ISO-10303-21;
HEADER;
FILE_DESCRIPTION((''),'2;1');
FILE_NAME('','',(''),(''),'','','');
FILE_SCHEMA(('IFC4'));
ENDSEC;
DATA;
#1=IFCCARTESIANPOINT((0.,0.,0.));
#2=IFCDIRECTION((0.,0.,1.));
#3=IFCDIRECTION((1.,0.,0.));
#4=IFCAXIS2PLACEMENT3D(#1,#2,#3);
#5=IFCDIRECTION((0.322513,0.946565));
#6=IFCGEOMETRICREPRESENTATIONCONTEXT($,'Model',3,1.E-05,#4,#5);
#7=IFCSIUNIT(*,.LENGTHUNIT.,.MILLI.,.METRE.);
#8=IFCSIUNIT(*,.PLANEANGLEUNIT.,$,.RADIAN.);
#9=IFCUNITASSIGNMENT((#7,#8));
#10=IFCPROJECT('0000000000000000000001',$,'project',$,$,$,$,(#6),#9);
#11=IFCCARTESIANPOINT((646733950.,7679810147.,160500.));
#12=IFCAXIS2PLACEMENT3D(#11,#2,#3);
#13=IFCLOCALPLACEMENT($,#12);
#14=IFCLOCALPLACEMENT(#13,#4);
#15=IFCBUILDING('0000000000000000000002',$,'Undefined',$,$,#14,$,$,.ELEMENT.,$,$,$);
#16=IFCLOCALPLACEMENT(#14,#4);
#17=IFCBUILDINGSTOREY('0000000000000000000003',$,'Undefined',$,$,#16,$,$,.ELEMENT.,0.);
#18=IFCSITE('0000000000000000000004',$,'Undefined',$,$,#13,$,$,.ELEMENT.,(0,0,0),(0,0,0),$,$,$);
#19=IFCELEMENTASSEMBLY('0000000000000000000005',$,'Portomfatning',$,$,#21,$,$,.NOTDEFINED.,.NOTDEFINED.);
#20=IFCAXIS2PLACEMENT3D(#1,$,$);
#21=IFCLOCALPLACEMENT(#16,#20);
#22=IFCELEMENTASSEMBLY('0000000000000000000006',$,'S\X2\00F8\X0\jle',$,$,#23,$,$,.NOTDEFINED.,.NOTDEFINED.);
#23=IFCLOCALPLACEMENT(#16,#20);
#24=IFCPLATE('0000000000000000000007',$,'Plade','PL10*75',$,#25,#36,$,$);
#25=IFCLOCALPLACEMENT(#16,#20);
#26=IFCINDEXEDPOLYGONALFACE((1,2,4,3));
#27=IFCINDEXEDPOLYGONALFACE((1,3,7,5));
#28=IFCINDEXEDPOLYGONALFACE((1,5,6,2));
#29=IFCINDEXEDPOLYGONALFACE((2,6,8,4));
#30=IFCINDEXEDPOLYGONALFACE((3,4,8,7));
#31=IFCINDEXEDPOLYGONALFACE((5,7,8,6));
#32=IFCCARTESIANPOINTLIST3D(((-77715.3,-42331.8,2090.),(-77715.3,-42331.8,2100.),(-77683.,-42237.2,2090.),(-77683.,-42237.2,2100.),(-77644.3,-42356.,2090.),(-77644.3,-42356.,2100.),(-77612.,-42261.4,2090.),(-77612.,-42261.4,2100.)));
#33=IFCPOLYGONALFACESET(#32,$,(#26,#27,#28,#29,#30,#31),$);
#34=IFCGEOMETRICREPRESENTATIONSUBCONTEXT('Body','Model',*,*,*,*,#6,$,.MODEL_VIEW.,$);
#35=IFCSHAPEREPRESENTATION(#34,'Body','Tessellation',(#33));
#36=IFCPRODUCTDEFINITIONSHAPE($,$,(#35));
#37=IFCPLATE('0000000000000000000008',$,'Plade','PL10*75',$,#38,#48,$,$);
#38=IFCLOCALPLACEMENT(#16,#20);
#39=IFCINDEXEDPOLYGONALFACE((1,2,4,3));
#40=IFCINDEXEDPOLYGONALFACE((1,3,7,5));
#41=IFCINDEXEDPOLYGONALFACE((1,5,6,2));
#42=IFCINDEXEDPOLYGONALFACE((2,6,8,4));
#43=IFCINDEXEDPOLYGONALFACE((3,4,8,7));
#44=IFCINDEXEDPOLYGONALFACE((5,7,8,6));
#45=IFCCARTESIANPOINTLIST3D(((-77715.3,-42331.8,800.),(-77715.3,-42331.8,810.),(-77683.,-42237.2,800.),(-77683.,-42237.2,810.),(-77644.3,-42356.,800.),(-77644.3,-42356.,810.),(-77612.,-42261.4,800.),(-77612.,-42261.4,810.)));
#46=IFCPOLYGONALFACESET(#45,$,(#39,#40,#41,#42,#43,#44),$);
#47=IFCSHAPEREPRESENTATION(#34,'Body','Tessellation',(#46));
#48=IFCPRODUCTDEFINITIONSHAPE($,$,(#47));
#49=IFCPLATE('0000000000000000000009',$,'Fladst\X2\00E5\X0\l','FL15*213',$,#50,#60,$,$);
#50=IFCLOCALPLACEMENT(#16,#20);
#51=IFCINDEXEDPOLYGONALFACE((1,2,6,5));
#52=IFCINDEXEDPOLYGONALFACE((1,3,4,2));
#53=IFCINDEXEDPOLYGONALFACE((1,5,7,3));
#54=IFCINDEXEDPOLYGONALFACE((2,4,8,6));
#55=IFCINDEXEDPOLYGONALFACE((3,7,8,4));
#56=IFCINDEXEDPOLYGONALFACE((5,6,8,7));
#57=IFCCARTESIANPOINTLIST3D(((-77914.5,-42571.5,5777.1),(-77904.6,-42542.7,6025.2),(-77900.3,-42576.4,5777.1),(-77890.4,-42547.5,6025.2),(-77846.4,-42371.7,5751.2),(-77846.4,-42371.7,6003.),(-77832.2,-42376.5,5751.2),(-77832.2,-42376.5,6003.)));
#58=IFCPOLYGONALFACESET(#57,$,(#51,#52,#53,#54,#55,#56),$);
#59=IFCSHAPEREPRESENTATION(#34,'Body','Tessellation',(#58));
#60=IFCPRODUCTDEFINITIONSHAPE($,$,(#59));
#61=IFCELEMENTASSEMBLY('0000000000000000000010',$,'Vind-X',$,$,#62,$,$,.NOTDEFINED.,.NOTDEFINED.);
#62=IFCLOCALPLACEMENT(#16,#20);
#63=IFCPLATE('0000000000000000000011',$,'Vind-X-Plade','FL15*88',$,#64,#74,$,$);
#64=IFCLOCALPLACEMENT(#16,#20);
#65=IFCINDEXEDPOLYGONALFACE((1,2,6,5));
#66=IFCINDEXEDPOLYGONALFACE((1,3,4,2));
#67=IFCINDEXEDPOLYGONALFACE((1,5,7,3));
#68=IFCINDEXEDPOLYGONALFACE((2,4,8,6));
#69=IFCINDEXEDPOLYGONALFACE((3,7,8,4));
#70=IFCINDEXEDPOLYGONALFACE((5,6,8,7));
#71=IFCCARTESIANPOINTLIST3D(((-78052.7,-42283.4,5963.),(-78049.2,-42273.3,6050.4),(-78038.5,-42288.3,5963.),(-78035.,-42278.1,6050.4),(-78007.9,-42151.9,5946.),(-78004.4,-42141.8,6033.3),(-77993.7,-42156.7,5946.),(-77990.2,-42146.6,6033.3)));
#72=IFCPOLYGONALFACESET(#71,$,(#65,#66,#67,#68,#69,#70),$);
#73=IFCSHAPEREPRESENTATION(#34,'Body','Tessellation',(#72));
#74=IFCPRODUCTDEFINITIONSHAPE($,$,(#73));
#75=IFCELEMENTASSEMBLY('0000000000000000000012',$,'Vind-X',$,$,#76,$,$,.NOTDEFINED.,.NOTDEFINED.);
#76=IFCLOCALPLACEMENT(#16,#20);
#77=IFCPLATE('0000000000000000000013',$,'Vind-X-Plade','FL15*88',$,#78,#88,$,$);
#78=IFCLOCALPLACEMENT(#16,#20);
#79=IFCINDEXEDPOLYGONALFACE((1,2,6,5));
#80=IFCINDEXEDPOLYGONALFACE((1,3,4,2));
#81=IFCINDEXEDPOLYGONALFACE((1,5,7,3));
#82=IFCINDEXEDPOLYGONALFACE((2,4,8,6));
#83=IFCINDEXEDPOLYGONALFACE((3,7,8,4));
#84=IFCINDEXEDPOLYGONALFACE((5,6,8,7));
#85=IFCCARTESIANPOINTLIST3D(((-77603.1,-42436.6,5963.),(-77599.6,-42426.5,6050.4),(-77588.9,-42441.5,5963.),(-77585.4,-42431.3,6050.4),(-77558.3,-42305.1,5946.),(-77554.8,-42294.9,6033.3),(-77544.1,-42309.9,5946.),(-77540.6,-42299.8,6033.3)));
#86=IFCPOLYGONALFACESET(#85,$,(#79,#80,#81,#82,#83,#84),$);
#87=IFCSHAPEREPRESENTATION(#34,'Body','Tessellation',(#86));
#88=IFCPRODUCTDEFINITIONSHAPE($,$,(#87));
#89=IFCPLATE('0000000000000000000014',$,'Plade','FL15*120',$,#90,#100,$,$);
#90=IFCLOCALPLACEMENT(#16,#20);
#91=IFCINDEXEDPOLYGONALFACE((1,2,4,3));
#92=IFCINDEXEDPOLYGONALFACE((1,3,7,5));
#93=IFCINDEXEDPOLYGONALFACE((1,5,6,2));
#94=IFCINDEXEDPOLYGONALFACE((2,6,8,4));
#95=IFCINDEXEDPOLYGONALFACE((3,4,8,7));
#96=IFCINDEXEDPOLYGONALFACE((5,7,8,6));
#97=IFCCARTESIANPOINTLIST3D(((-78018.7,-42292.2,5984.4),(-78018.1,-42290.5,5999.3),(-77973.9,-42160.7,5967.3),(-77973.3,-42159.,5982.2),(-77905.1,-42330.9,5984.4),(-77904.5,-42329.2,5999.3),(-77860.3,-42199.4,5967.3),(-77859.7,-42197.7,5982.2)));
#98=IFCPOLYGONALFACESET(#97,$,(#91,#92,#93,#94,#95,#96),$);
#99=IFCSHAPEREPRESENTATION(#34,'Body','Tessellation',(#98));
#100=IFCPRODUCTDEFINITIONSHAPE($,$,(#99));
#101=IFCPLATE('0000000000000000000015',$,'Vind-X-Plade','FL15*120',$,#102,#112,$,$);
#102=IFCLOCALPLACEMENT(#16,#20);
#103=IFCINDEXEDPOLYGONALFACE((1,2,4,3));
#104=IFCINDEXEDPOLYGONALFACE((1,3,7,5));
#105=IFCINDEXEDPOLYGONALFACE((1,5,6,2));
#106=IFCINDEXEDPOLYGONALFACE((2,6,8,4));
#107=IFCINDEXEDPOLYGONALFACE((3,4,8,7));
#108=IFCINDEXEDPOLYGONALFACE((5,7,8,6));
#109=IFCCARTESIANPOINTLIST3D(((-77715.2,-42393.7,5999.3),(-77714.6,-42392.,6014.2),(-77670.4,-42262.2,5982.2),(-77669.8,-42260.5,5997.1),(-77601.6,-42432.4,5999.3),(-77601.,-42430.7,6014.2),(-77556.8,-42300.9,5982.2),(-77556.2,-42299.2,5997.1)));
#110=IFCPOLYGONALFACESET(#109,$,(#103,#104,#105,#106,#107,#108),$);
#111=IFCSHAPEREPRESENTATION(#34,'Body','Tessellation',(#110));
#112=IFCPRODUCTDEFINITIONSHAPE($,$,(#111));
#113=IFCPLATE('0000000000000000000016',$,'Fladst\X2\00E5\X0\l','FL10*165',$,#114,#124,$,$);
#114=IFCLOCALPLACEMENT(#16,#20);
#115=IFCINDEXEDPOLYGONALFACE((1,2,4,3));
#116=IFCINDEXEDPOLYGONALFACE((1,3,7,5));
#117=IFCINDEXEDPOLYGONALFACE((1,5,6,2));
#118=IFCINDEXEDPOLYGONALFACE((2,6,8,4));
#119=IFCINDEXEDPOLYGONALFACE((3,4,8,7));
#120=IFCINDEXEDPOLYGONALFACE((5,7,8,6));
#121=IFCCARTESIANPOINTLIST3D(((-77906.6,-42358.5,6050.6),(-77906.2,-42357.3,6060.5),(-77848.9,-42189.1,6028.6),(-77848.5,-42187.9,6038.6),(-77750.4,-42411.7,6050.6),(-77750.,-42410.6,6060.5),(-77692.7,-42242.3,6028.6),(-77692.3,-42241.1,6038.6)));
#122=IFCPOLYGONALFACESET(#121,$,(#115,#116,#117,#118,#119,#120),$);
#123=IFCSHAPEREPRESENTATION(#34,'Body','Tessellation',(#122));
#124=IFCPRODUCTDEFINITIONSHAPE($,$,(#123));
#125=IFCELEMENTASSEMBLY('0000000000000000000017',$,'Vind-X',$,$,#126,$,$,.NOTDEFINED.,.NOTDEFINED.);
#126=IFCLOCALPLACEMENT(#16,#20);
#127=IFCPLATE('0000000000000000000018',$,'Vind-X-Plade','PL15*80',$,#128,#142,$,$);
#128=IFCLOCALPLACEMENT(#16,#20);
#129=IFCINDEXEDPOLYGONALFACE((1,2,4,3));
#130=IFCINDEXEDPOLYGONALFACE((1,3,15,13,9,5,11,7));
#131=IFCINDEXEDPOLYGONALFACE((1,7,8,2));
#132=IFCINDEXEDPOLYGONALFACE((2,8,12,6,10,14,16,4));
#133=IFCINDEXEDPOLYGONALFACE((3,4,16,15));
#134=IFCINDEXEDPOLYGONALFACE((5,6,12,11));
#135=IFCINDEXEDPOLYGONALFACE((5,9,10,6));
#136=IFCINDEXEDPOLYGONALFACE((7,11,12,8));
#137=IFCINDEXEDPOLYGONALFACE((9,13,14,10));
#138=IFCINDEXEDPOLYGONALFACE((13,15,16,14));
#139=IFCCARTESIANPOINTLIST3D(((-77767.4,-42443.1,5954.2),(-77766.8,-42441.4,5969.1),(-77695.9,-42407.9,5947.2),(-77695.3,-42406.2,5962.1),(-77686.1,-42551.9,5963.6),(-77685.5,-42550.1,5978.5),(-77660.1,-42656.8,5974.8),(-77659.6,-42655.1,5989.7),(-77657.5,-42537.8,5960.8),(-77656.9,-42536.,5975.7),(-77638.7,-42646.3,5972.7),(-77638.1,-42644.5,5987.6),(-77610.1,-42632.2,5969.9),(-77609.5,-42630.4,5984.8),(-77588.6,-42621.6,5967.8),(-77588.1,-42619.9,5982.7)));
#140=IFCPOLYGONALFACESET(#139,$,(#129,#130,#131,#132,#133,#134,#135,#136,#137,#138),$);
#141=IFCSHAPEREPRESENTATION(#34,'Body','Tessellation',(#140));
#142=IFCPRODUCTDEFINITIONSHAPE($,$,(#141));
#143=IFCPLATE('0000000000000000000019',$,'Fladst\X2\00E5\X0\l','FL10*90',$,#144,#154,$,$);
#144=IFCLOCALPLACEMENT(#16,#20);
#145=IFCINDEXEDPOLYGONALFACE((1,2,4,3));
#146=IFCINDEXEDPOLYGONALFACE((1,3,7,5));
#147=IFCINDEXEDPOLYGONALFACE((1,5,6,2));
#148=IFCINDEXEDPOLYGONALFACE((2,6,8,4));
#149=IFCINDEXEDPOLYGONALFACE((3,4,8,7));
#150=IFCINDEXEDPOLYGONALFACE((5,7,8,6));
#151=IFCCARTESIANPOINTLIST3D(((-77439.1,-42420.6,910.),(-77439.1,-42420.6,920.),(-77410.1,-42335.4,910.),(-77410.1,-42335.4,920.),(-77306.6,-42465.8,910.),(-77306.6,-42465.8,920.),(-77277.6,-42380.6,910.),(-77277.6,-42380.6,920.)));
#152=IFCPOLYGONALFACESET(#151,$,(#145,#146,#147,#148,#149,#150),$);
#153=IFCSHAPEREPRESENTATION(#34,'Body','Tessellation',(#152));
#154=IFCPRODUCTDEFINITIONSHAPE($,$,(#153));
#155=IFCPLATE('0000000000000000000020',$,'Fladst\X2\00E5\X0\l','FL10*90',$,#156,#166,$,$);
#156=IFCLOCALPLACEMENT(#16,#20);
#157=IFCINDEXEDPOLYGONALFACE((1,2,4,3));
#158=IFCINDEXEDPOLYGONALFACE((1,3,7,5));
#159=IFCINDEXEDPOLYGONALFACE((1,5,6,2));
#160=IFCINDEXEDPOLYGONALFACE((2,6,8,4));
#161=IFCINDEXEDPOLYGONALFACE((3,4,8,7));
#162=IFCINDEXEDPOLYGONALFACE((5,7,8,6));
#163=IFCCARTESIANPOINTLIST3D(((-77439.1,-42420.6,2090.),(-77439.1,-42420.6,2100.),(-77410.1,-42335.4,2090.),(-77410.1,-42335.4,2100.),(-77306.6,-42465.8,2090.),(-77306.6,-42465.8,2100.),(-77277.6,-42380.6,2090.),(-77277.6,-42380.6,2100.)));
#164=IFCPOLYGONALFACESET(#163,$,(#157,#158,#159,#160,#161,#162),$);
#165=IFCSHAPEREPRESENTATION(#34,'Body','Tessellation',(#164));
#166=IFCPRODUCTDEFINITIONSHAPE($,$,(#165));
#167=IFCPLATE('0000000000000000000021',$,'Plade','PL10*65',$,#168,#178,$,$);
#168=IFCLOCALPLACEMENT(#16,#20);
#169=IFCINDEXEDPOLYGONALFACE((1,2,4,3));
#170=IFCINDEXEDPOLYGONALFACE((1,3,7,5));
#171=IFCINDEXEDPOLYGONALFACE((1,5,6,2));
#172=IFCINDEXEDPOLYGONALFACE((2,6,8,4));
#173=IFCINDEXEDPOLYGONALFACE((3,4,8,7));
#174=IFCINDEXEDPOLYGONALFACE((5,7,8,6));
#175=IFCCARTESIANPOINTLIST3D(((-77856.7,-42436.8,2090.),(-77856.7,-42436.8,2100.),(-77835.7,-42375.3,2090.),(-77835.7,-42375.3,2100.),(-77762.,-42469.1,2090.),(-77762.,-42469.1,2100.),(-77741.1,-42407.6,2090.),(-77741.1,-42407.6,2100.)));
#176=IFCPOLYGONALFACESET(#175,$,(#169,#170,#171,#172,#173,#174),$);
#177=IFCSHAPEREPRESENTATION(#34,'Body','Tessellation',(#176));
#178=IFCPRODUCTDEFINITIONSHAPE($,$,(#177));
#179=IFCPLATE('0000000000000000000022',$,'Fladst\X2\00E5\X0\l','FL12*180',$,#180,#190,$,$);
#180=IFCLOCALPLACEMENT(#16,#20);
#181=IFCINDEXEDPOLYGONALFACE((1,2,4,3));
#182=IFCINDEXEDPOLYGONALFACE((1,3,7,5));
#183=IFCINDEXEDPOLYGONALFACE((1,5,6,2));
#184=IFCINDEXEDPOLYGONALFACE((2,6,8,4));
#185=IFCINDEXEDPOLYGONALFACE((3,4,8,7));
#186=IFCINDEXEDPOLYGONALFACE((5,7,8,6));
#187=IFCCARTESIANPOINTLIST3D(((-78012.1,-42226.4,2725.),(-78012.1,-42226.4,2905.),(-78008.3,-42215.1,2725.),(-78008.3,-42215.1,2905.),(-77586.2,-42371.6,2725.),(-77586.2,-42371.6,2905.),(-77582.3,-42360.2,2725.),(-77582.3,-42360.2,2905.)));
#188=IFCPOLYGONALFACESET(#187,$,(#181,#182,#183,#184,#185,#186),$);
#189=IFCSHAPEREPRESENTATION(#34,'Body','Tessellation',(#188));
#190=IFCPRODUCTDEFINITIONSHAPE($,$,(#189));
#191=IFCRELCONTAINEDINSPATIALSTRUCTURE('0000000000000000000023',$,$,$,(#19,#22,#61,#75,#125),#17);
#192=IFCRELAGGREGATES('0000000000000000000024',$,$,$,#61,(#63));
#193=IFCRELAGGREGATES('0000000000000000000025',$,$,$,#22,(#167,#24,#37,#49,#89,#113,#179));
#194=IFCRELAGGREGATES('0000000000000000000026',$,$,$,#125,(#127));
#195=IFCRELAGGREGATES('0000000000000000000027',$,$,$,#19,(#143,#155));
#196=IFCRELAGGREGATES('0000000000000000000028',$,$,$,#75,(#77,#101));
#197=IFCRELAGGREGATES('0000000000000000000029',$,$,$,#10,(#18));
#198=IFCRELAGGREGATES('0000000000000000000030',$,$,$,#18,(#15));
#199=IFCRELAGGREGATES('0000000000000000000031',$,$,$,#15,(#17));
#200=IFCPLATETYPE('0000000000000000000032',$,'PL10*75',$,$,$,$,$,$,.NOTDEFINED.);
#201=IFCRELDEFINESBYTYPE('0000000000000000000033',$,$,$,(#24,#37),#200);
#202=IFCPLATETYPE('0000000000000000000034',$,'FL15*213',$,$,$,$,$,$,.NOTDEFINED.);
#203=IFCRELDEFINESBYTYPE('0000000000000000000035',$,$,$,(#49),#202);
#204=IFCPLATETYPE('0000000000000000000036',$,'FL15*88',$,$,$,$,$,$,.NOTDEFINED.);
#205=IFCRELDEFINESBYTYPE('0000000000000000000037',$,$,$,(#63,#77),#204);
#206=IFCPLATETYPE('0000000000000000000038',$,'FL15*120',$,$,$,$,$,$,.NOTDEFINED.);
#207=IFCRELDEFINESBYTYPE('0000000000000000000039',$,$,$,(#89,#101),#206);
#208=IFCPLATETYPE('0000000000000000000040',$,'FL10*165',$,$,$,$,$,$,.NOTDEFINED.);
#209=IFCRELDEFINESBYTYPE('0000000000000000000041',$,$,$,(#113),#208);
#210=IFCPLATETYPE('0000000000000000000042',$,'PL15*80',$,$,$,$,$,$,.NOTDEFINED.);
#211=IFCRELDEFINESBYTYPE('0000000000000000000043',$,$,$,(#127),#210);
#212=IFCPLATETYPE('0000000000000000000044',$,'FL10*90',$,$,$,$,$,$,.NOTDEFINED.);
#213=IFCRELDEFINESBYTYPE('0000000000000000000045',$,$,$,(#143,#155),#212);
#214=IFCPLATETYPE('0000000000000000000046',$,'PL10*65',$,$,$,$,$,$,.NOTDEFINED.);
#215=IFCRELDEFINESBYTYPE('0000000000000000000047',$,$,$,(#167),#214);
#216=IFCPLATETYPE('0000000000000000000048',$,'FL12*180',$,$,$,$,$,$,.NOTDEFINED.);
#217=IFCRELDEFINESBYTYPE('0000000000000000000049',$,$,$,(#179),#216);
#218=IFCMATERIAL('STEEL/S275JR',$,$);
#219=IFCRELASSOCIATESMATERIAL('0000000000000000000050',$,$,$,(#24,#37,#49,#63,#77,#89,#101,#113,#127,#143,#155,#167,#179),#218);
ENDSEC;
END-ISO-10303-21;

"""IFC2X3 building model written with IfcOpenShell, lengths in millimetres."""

from ifc_helpers import new_model, si_unit, direction, frame, origin_with_axes, place, context, subcontext, project, spatial, polyline, outline, extrude, boolean, material, type_object, element, aggregate, save


model = new_model("IFC2X3")

# Units and contexts
model_context = context("Model", 3, precision=1e-05, world=origin_with_axes(), true_north=direction((0.322513, 0.946565)))
body_context = subcontext(model_context, "Body", "Model", "MODEL_VIEW")
ifc_project = project(units=[si_unit("LENGTHUNIT", "METRE", prefix="MILLI"), si_unit("PLANEANGLEUNIT", "RADIAN")], contexts=[model_context])

# Site, building, storey
site_placement = place(None, frame((646733950.0, 7679810147.0, 160500.0), z_axis=(0.0, 0.0, 1.0), x_axis=(1.0, 0.0, 0.0)))
site = spatial("IfcSite", under=ifc_project, at=site_placement, Name="Undefined", CompositionType="ELEMENT", RefLatitude=(0, 0, 0), RefLongitude=(0, 0, 0))
building_placement = place(site_placement, origin_with_axes())
building = spatial("IfcBuilding", under=site, at=building_placement, Name="Undefined", CompositionType="ELEMENT")
storey_placement = place(building_placement, origin_with_axes())
storey = spatial("IfcBuildingStorey", under=building, at=storey_placement, Name="Undefined", CompositionType="ELEMENT", Elevation=0.0)

# Element assemblies
assembly_1_placement = place(storey_placement, origin_with_axes())
assembly_1 = element("IfcElementAssembly", 1, at=assembly_1_placement, inside=storey, Name="Portomfatning", AssemblyPlace="NOTDEFINED", PredefinedType="NOTDEFINED")
assembly_2_placement = place(storey_placement, origin_with_axes())
assembly_2 = element("IfcElementAssembly", 2, at=assembly_2_placement, inside=storey, Name="Søjle", AssemblyPlace="NOTDEFINED", PredefinedType="NOTDEFINED")

# Plates
ifc_material_1 = material(Name="STEEL/S275JR")
plate_type_1 = type_object("IfcPlateType", Name="PL10*75", PredefinedType="NOTDEFINED")
plate_1_placement = place(assembly_2_placement, frame((-77715.3, -42331.8, 2095.0), z_axis=(0.0, 0.0, 1.0), x_axis=(0.946565, -0.322513, 0.0)))
plate_1 = element("IfcPlate", 3, at=plate_1_placement, type_object=plate_type_1, material=ifc_material_1, Name="Plade", Description="PL10*75", context=body_context, shape_type="SweptSolid", body=[
    extrude(outline(polyline([(0.0, 0.0), (75.0, 0.0), (75.0, 100.0), (0.0, 100.0), (0.0, 0.0)])), frame((0.0, 0.0, -5.0), z_axis=(0.0, 0.0, 1.0), x_axis=(1.0, 0.0, 0.0)), (0.0, 0.0, 1.0), 10.0),
])
plate_2_placement = place(assembly_2_placement, frame((-77715.3, -42331.8, 805.0), z_axis=(0.0, 0.0, 1.0), x_axis=(0.946565, -0.322513, 0.0)))
plate_2 = element("IfcPlate", 4, at=plate_2_placement, type_object=plate_type_1, material=ifc_material_1, Name="Plade", Description="PL10*75", context=body_context, shape_type="SweptSolid", body=[
    extrude(outline(polyline([(0.0, 0.0), (75.0, 0.0), (75.0, 100.0), (0.0, 100.0), (0.0, 0.0)])), frame((0.0, 0.0, -5.0), z_axis=(0.0, 0.0, 1.0), x_axis=(1.0, 0.0, 0.0)), (0.0, 0.0, 1.0), 10.0),
])
plate_type_2 = type_object("IfcPlateType", Name="FL15*213", PredefinedType="NOTDEFINED")
plate_3_placement = place(assembly_2_placement, frame((-77839.3, -42374.1, 6003.0), z_axis=(-0.946565, 0.322513, 0.0), x_axis=(0.0, 0.0, -1.0)))
plate_3 = element("IfcPlate", 5, at=plate_3_placement, type_object=plate_type_2, material=ifc_material_1, Name="Fladstål", Description="FL15*213", context=body_context, shape_type="SweptSolid", body=[
    extrude(outline(polyline([(0.0, 0.0), (251.9, 0.0), (226.0, 211.1), (-22.2, 180.7), (0.0, 0.0)])), frame((0.0, 0.0, -7.5), z_axis=(0.0, 0.0, 1.0), x_axis=(1.0, 0.0, 0.0)), (0.0, 0.0, 1.0), 15.0),
])

# Element assemblies, plates
assembly_3_placement = place(storey_placement, origin_with_axes())
assembly_3 = element("IfcElementAssembly", 6, at=assembly_3_placement, inside=storey, Name="Vind-X", AssemblyPlace="NOTDEFINED", PredefinedType="NOTDEFINED")
plate_type_3 = type_object("IfcPlateType", Name="FL15*88", PredefinedType="NOTDEFINED")
plate_4_placement = place(assembly_3_placement, frame((-78045.6, -42285.9, 5963.0), z_axis=(0.946565, -0.322513, 0.0), x_axis=(0.320109, 0.93951, -0.121869)))
plate_4 = element("IfcPlate", 7, at=plate_4_placement, type_object=plate_type_3, material=ifc_material_1, Name="Vind-X-Plade", Description="FL15*88", context=body_context, shape_type="SweptSolid", body=[
    extrude(outline(polyline([(0.0, 0.0), (140.0, 0.0), (140.0, 88.0), (0.0, 88.0), (0.0, 0.0)])), frame((0.0, 0.0, -7.5), z_axis=(0.0, 0.0, 1.0), x_axis=(1.0, 0.0, 0.0)), (0.0, 0.0, 1.0), 15.0),
])
aggregate(assembly_3, [plate_4])
assembly_4_placement = place(storey_placement, origin_with_axes())
assembly_4 = element("IfcElementAssembly", 8, at=assembly_4_placement, inside=storey, Name="Vind-X", AssemblyPlace="NOTDEFINED", PredefinedType="NOTDEFINED")
plate_5_placement = place(assembly_4_placement, frame((-77592.5, -42428.9, 6050.4), z_axis=(-0.946565, 0.322513, 0.0), x_axis=(0.320109, 0.93951, -0.121869)))
plate_5 = element("IfcPlate", 9, at=plate_5_placement, type_object=plate_type_3, material=ifc_material_1, Name="Vind-X-Plade", Description="FL15*88", context=body_context, shape_type="SweptSolid", body=[
    extrude(outline(polyline([(0.0, 0.0), (140.0, 0.0), (140.0, 88.0), (0.0, 88.0), (0.0, 0.0)])), frame((0.0, 0.0, -7.5), z_axis=(0.0, 0.0, 1.0), x_axis=(1.0, 0.0, 0.0)), (0.0, 0.0, 1.0), 15.0),
])

# Plates
plate_type_4 = type_object("IfcPlateType", Name="FL15*120", PredefinedType="NOTDEFINED")
plate_6_placement = place(assembly_2_placement, frame((-77904.8, -42330.1, 5991.8), z_axis=(0.039304, 0.115357, 0.992546), x_axis=(0.320109, 0.93951, -0.121869)))
plate_6 = element("IfcPlate", 10, at=plate_6_placement, type_object=plate_type_4, material=ifc_material_1, Name="Plade", Description="FL15*120", context=body_context, shape_type="SweptSolid", body=[
    extrude(outline(polyline([(0.0, 0.0), (140.0, 0.0), (140.0, 120.0), (0.0, 120.0), (0.0, 0.0)])), frame((0.0, 0.0, -7.5), z_axis=(0.0, 0.0, 1.0), x_axis=(1.0, 0.0, 0.0)), (0.0, 0.0, 1.0), 15.0),
])
plate_7_placement = place(assembly_4_placement, frame((-77692.5, -42327.1, 5998.2), z_axis=(0.039304, 0.115357, 0.992546), x_axis=(0.946565, -0.322513, 0.0)))
plate_7 = element("IfcPlate", 11, at=plate_7_placement, type_object=plate_type_4, material=ifc_material_1, Name="Vind-X-Plade", Description="FL15*120", context=body_context, shape_type="SweptSolid", body=[
    extrude(outline(polyline([(0.0, -70.0), (0.0, 70.0), (120.0, 70.0), (120.0, -70.0), (0.0, -70.0)])), frame((0.0, 0.0, -7.5), z_axis=(0.0, 0.0, 1.0), x_axis=(1.0, 0.0, 0.0)), (0.0, 0.0, 1.0), 15.0),
])
plate_type_5 = type_object("IfcPlateType", Name="FL10*165", PredefinedType="NOTDEFINED")
plate_8_placement = place(assembly_2_placement, frame((-77828.3, -42384.5, 6055.6), z_axis=(-0.039304, -0.115357, -0.992546), x_axis=(0.320109, 0.93951, -0.121869)))
plate_8 = element("IfcPlate", 12, at=plate_8_placement, type_object=plate_type_5, material=ifc_material_1, Name="Fladstål", Description="FL10*165", context=body_context, shape_type="SweptSolid", body=[
    extrude(outline(polyline([(0.0, -82.5), (0.0, 82.5), (180.4, 82.5), (180.4, -82.5), (0.0, -82.5)])), frame((0.0, 0.0, -5.0), z_axis=(0.0, 0.0, 1.0), x_axis=(1.0, 0.0, 0.0)), (0.0, 0.0, 1.0), 10.0),
])

# Element assembly, plate
assembly_5_placement = place(storey_placement, origin_with_axes())
assembly_5 = element("IfcElementAssembly", 13, at=assembly_5_placement, inside=storey, Name="Vind-X", AssemblyPlace="NOTDEFINED", PredefinedType="NOTDEFINED")
plate_type_6 = type_object("IfcPlateType", Name="PL15*80", PredefinedType="NOTDEFINED")
plate_9_placement = place(assembly_5_placement, frame((-77767.1, -42442.2, 5961.6), z_axis=(-0.039304, -0.115357, -0.992546), x_axis=(0.893742, 0.440152, -0.086548)))
plate_9 = element("IfcPlate", 14, at=plate_9_placement, type_object=plate_type_6, material=ifc_material_1, Name="Vind-X-Plade", Description="PL15*80", context=body_context, shape_type="CSG", body=[
    boolean("DIFFERENCE", extrude(outline(polyline([(0.0, 0.0), (80.0, 0.0), (80.0, 240.0), (0.0, 240.0), (0.0, 0.0)])), frame((0.0, 0.0, -7.5), z_axis=(0.0, 0.0, 1.0), x_axis=(1.0, 0.0, 0.0)), (0.0, 0.0, 1.0), 15.0), extrude(outline(polyline([(0.0, 0.0), (106.0, 0.0), (106.0, 32.0), (0.0, 32.0), (0.0, 0.0)])), frame((56.0, 240.0, 8.5), z_axis=(0.0, 0.0, -1.0), x_axis=(0.0, -1.0, 0.0)), (0.0, 0.0, 1.0), 17.0)),
])

# Plates
plate_type_7 = type_object("IfcPlateType", Name="FL10*90", PredefinedType="NOTDEFINED")
plate_10_placement = place(assembly_1_placement, frame((-77292.1, -42423.2, 915.0), z_axis=(0.0, 0.0, 1.0), x_axis=(-0.946565, 0.322513, 0.0)))
plate_10 = element("IfcPlate", 15, at=plate_10_placement, type_object=plate_type_7, material=ifc_material_1, Name="Fladstål", Description="FL10*90", context=body_context, shape_type="SweptSolid", body=[
    extrude(outline(polyline([(0.0, -45.0), (0.0, 45.0), (140.0, 45.0), (140.0, -45.0), (0.0, -45.0)])), frame((0.0, 0.0, -5.0), z_axis=(0.0, 0.0, 1.0), x_axis=(1.0, 0.0, 0.0)), (0.0, 0.0, 1.0), 10.0),
])
plate_11_placement = place(assembly_1_placement, frame((-77292.1, -42423.2, 2095.0), z_axis=(0.0, 0.0, -1.0), x_axis=(-0.946565, 0.322513, 0.0)))
plate_11 = element("IfcPlate", 16, at=plate_11_placement, type_object=plate_type_7, material=ifc_material_1, Name="Fladstål", Description="FL10*90", context=body_context, shape_type="SweptSolid", body=[
    extrude(outline(polyline([(0.0, -45.0), (0.0, 45.0), (140.0, 45.0), (140.0, -45.0), (0.0, -45.0)])), frame((0.0, 0.0, -5.0), z_axis=(0.0, 0.0, 1.0), x_axis=(1.0, 0.0, 0.0)), (0.0, 0.0, 1.0), 10.0),
])
plate_type_8 = type_object("IfcPlateType", Name="PL10*65", PredefinedType="NOTDEFINED")
plate_12_placement = place(assembly_2_placement, frame((-77835.7, -42375.3, 2095.0), z_axis=(0.0, 0.0, 1.0), x_axis=(-0.322513, -0.946565, 0.0)))
plate_12 = element("IfcPlate", 17, at=plate_12_placement, type_object=plate_type_8, material=ifc_material_1, Name="Plade", Description="PL10*65", context=body_context, shape_type="SweptSolid", body=[
    extrude(outline(polyline([(0.0, 0.0), (65.0, 0.0), (65.0, 100.0), (0.0, 100.0), (0.0, 0.0)])), frame((0.0, 0.0, -5.0), z_axis=(0.0, 0.0, 1.0), x_axis=(1.0, 0.0, 0.0)), (0.0, 0.0, 1.0), 10.0),
])
plate_type_9 = type_object("IfcPlateType", Name="FL12*180", PredefinedType="NOTDEFINED")
plate_13_placement = place(assembly_2_placement, frame((-77584.3, -42365.9, 2905.0), z_axis=(0.322513, 0.946565, 0.0), x_axis=(0.0, 0.0, -1.0)))
plate_13 = element("IfcPlate", 18, at=plate_13_placement, type_object=plate_type_9, material=ifc_material_1, Name="Fladstål", Description="FL12*180", context=body_context, shape_type="SweptSolid", body=[
    extrude(outline(polyline([(0.0, 0.0), (180.0, 0.0), (180.0, 450.0), (0.0, 450.0), (0.0, 0.0)])), frame((0.0, 0.0, -6.0), z_axis=(0.0, 0.0, 1.0), x_axis=(1.0, 0.0, 0.0)), (0.0, 0.0, 1.0), 12.0),
])

aggregate(assembly_2, [plate_12, plate_1, plate_2, plate_3, plate_6, plate_8, plate_13])

aggregate(assembly_5, [plate_9])
aggregate(assembly_1, [plate_10, plate_11])

aggregate(assembly_4, [plate_5, plate_7])

save(model, "model.ifc")
